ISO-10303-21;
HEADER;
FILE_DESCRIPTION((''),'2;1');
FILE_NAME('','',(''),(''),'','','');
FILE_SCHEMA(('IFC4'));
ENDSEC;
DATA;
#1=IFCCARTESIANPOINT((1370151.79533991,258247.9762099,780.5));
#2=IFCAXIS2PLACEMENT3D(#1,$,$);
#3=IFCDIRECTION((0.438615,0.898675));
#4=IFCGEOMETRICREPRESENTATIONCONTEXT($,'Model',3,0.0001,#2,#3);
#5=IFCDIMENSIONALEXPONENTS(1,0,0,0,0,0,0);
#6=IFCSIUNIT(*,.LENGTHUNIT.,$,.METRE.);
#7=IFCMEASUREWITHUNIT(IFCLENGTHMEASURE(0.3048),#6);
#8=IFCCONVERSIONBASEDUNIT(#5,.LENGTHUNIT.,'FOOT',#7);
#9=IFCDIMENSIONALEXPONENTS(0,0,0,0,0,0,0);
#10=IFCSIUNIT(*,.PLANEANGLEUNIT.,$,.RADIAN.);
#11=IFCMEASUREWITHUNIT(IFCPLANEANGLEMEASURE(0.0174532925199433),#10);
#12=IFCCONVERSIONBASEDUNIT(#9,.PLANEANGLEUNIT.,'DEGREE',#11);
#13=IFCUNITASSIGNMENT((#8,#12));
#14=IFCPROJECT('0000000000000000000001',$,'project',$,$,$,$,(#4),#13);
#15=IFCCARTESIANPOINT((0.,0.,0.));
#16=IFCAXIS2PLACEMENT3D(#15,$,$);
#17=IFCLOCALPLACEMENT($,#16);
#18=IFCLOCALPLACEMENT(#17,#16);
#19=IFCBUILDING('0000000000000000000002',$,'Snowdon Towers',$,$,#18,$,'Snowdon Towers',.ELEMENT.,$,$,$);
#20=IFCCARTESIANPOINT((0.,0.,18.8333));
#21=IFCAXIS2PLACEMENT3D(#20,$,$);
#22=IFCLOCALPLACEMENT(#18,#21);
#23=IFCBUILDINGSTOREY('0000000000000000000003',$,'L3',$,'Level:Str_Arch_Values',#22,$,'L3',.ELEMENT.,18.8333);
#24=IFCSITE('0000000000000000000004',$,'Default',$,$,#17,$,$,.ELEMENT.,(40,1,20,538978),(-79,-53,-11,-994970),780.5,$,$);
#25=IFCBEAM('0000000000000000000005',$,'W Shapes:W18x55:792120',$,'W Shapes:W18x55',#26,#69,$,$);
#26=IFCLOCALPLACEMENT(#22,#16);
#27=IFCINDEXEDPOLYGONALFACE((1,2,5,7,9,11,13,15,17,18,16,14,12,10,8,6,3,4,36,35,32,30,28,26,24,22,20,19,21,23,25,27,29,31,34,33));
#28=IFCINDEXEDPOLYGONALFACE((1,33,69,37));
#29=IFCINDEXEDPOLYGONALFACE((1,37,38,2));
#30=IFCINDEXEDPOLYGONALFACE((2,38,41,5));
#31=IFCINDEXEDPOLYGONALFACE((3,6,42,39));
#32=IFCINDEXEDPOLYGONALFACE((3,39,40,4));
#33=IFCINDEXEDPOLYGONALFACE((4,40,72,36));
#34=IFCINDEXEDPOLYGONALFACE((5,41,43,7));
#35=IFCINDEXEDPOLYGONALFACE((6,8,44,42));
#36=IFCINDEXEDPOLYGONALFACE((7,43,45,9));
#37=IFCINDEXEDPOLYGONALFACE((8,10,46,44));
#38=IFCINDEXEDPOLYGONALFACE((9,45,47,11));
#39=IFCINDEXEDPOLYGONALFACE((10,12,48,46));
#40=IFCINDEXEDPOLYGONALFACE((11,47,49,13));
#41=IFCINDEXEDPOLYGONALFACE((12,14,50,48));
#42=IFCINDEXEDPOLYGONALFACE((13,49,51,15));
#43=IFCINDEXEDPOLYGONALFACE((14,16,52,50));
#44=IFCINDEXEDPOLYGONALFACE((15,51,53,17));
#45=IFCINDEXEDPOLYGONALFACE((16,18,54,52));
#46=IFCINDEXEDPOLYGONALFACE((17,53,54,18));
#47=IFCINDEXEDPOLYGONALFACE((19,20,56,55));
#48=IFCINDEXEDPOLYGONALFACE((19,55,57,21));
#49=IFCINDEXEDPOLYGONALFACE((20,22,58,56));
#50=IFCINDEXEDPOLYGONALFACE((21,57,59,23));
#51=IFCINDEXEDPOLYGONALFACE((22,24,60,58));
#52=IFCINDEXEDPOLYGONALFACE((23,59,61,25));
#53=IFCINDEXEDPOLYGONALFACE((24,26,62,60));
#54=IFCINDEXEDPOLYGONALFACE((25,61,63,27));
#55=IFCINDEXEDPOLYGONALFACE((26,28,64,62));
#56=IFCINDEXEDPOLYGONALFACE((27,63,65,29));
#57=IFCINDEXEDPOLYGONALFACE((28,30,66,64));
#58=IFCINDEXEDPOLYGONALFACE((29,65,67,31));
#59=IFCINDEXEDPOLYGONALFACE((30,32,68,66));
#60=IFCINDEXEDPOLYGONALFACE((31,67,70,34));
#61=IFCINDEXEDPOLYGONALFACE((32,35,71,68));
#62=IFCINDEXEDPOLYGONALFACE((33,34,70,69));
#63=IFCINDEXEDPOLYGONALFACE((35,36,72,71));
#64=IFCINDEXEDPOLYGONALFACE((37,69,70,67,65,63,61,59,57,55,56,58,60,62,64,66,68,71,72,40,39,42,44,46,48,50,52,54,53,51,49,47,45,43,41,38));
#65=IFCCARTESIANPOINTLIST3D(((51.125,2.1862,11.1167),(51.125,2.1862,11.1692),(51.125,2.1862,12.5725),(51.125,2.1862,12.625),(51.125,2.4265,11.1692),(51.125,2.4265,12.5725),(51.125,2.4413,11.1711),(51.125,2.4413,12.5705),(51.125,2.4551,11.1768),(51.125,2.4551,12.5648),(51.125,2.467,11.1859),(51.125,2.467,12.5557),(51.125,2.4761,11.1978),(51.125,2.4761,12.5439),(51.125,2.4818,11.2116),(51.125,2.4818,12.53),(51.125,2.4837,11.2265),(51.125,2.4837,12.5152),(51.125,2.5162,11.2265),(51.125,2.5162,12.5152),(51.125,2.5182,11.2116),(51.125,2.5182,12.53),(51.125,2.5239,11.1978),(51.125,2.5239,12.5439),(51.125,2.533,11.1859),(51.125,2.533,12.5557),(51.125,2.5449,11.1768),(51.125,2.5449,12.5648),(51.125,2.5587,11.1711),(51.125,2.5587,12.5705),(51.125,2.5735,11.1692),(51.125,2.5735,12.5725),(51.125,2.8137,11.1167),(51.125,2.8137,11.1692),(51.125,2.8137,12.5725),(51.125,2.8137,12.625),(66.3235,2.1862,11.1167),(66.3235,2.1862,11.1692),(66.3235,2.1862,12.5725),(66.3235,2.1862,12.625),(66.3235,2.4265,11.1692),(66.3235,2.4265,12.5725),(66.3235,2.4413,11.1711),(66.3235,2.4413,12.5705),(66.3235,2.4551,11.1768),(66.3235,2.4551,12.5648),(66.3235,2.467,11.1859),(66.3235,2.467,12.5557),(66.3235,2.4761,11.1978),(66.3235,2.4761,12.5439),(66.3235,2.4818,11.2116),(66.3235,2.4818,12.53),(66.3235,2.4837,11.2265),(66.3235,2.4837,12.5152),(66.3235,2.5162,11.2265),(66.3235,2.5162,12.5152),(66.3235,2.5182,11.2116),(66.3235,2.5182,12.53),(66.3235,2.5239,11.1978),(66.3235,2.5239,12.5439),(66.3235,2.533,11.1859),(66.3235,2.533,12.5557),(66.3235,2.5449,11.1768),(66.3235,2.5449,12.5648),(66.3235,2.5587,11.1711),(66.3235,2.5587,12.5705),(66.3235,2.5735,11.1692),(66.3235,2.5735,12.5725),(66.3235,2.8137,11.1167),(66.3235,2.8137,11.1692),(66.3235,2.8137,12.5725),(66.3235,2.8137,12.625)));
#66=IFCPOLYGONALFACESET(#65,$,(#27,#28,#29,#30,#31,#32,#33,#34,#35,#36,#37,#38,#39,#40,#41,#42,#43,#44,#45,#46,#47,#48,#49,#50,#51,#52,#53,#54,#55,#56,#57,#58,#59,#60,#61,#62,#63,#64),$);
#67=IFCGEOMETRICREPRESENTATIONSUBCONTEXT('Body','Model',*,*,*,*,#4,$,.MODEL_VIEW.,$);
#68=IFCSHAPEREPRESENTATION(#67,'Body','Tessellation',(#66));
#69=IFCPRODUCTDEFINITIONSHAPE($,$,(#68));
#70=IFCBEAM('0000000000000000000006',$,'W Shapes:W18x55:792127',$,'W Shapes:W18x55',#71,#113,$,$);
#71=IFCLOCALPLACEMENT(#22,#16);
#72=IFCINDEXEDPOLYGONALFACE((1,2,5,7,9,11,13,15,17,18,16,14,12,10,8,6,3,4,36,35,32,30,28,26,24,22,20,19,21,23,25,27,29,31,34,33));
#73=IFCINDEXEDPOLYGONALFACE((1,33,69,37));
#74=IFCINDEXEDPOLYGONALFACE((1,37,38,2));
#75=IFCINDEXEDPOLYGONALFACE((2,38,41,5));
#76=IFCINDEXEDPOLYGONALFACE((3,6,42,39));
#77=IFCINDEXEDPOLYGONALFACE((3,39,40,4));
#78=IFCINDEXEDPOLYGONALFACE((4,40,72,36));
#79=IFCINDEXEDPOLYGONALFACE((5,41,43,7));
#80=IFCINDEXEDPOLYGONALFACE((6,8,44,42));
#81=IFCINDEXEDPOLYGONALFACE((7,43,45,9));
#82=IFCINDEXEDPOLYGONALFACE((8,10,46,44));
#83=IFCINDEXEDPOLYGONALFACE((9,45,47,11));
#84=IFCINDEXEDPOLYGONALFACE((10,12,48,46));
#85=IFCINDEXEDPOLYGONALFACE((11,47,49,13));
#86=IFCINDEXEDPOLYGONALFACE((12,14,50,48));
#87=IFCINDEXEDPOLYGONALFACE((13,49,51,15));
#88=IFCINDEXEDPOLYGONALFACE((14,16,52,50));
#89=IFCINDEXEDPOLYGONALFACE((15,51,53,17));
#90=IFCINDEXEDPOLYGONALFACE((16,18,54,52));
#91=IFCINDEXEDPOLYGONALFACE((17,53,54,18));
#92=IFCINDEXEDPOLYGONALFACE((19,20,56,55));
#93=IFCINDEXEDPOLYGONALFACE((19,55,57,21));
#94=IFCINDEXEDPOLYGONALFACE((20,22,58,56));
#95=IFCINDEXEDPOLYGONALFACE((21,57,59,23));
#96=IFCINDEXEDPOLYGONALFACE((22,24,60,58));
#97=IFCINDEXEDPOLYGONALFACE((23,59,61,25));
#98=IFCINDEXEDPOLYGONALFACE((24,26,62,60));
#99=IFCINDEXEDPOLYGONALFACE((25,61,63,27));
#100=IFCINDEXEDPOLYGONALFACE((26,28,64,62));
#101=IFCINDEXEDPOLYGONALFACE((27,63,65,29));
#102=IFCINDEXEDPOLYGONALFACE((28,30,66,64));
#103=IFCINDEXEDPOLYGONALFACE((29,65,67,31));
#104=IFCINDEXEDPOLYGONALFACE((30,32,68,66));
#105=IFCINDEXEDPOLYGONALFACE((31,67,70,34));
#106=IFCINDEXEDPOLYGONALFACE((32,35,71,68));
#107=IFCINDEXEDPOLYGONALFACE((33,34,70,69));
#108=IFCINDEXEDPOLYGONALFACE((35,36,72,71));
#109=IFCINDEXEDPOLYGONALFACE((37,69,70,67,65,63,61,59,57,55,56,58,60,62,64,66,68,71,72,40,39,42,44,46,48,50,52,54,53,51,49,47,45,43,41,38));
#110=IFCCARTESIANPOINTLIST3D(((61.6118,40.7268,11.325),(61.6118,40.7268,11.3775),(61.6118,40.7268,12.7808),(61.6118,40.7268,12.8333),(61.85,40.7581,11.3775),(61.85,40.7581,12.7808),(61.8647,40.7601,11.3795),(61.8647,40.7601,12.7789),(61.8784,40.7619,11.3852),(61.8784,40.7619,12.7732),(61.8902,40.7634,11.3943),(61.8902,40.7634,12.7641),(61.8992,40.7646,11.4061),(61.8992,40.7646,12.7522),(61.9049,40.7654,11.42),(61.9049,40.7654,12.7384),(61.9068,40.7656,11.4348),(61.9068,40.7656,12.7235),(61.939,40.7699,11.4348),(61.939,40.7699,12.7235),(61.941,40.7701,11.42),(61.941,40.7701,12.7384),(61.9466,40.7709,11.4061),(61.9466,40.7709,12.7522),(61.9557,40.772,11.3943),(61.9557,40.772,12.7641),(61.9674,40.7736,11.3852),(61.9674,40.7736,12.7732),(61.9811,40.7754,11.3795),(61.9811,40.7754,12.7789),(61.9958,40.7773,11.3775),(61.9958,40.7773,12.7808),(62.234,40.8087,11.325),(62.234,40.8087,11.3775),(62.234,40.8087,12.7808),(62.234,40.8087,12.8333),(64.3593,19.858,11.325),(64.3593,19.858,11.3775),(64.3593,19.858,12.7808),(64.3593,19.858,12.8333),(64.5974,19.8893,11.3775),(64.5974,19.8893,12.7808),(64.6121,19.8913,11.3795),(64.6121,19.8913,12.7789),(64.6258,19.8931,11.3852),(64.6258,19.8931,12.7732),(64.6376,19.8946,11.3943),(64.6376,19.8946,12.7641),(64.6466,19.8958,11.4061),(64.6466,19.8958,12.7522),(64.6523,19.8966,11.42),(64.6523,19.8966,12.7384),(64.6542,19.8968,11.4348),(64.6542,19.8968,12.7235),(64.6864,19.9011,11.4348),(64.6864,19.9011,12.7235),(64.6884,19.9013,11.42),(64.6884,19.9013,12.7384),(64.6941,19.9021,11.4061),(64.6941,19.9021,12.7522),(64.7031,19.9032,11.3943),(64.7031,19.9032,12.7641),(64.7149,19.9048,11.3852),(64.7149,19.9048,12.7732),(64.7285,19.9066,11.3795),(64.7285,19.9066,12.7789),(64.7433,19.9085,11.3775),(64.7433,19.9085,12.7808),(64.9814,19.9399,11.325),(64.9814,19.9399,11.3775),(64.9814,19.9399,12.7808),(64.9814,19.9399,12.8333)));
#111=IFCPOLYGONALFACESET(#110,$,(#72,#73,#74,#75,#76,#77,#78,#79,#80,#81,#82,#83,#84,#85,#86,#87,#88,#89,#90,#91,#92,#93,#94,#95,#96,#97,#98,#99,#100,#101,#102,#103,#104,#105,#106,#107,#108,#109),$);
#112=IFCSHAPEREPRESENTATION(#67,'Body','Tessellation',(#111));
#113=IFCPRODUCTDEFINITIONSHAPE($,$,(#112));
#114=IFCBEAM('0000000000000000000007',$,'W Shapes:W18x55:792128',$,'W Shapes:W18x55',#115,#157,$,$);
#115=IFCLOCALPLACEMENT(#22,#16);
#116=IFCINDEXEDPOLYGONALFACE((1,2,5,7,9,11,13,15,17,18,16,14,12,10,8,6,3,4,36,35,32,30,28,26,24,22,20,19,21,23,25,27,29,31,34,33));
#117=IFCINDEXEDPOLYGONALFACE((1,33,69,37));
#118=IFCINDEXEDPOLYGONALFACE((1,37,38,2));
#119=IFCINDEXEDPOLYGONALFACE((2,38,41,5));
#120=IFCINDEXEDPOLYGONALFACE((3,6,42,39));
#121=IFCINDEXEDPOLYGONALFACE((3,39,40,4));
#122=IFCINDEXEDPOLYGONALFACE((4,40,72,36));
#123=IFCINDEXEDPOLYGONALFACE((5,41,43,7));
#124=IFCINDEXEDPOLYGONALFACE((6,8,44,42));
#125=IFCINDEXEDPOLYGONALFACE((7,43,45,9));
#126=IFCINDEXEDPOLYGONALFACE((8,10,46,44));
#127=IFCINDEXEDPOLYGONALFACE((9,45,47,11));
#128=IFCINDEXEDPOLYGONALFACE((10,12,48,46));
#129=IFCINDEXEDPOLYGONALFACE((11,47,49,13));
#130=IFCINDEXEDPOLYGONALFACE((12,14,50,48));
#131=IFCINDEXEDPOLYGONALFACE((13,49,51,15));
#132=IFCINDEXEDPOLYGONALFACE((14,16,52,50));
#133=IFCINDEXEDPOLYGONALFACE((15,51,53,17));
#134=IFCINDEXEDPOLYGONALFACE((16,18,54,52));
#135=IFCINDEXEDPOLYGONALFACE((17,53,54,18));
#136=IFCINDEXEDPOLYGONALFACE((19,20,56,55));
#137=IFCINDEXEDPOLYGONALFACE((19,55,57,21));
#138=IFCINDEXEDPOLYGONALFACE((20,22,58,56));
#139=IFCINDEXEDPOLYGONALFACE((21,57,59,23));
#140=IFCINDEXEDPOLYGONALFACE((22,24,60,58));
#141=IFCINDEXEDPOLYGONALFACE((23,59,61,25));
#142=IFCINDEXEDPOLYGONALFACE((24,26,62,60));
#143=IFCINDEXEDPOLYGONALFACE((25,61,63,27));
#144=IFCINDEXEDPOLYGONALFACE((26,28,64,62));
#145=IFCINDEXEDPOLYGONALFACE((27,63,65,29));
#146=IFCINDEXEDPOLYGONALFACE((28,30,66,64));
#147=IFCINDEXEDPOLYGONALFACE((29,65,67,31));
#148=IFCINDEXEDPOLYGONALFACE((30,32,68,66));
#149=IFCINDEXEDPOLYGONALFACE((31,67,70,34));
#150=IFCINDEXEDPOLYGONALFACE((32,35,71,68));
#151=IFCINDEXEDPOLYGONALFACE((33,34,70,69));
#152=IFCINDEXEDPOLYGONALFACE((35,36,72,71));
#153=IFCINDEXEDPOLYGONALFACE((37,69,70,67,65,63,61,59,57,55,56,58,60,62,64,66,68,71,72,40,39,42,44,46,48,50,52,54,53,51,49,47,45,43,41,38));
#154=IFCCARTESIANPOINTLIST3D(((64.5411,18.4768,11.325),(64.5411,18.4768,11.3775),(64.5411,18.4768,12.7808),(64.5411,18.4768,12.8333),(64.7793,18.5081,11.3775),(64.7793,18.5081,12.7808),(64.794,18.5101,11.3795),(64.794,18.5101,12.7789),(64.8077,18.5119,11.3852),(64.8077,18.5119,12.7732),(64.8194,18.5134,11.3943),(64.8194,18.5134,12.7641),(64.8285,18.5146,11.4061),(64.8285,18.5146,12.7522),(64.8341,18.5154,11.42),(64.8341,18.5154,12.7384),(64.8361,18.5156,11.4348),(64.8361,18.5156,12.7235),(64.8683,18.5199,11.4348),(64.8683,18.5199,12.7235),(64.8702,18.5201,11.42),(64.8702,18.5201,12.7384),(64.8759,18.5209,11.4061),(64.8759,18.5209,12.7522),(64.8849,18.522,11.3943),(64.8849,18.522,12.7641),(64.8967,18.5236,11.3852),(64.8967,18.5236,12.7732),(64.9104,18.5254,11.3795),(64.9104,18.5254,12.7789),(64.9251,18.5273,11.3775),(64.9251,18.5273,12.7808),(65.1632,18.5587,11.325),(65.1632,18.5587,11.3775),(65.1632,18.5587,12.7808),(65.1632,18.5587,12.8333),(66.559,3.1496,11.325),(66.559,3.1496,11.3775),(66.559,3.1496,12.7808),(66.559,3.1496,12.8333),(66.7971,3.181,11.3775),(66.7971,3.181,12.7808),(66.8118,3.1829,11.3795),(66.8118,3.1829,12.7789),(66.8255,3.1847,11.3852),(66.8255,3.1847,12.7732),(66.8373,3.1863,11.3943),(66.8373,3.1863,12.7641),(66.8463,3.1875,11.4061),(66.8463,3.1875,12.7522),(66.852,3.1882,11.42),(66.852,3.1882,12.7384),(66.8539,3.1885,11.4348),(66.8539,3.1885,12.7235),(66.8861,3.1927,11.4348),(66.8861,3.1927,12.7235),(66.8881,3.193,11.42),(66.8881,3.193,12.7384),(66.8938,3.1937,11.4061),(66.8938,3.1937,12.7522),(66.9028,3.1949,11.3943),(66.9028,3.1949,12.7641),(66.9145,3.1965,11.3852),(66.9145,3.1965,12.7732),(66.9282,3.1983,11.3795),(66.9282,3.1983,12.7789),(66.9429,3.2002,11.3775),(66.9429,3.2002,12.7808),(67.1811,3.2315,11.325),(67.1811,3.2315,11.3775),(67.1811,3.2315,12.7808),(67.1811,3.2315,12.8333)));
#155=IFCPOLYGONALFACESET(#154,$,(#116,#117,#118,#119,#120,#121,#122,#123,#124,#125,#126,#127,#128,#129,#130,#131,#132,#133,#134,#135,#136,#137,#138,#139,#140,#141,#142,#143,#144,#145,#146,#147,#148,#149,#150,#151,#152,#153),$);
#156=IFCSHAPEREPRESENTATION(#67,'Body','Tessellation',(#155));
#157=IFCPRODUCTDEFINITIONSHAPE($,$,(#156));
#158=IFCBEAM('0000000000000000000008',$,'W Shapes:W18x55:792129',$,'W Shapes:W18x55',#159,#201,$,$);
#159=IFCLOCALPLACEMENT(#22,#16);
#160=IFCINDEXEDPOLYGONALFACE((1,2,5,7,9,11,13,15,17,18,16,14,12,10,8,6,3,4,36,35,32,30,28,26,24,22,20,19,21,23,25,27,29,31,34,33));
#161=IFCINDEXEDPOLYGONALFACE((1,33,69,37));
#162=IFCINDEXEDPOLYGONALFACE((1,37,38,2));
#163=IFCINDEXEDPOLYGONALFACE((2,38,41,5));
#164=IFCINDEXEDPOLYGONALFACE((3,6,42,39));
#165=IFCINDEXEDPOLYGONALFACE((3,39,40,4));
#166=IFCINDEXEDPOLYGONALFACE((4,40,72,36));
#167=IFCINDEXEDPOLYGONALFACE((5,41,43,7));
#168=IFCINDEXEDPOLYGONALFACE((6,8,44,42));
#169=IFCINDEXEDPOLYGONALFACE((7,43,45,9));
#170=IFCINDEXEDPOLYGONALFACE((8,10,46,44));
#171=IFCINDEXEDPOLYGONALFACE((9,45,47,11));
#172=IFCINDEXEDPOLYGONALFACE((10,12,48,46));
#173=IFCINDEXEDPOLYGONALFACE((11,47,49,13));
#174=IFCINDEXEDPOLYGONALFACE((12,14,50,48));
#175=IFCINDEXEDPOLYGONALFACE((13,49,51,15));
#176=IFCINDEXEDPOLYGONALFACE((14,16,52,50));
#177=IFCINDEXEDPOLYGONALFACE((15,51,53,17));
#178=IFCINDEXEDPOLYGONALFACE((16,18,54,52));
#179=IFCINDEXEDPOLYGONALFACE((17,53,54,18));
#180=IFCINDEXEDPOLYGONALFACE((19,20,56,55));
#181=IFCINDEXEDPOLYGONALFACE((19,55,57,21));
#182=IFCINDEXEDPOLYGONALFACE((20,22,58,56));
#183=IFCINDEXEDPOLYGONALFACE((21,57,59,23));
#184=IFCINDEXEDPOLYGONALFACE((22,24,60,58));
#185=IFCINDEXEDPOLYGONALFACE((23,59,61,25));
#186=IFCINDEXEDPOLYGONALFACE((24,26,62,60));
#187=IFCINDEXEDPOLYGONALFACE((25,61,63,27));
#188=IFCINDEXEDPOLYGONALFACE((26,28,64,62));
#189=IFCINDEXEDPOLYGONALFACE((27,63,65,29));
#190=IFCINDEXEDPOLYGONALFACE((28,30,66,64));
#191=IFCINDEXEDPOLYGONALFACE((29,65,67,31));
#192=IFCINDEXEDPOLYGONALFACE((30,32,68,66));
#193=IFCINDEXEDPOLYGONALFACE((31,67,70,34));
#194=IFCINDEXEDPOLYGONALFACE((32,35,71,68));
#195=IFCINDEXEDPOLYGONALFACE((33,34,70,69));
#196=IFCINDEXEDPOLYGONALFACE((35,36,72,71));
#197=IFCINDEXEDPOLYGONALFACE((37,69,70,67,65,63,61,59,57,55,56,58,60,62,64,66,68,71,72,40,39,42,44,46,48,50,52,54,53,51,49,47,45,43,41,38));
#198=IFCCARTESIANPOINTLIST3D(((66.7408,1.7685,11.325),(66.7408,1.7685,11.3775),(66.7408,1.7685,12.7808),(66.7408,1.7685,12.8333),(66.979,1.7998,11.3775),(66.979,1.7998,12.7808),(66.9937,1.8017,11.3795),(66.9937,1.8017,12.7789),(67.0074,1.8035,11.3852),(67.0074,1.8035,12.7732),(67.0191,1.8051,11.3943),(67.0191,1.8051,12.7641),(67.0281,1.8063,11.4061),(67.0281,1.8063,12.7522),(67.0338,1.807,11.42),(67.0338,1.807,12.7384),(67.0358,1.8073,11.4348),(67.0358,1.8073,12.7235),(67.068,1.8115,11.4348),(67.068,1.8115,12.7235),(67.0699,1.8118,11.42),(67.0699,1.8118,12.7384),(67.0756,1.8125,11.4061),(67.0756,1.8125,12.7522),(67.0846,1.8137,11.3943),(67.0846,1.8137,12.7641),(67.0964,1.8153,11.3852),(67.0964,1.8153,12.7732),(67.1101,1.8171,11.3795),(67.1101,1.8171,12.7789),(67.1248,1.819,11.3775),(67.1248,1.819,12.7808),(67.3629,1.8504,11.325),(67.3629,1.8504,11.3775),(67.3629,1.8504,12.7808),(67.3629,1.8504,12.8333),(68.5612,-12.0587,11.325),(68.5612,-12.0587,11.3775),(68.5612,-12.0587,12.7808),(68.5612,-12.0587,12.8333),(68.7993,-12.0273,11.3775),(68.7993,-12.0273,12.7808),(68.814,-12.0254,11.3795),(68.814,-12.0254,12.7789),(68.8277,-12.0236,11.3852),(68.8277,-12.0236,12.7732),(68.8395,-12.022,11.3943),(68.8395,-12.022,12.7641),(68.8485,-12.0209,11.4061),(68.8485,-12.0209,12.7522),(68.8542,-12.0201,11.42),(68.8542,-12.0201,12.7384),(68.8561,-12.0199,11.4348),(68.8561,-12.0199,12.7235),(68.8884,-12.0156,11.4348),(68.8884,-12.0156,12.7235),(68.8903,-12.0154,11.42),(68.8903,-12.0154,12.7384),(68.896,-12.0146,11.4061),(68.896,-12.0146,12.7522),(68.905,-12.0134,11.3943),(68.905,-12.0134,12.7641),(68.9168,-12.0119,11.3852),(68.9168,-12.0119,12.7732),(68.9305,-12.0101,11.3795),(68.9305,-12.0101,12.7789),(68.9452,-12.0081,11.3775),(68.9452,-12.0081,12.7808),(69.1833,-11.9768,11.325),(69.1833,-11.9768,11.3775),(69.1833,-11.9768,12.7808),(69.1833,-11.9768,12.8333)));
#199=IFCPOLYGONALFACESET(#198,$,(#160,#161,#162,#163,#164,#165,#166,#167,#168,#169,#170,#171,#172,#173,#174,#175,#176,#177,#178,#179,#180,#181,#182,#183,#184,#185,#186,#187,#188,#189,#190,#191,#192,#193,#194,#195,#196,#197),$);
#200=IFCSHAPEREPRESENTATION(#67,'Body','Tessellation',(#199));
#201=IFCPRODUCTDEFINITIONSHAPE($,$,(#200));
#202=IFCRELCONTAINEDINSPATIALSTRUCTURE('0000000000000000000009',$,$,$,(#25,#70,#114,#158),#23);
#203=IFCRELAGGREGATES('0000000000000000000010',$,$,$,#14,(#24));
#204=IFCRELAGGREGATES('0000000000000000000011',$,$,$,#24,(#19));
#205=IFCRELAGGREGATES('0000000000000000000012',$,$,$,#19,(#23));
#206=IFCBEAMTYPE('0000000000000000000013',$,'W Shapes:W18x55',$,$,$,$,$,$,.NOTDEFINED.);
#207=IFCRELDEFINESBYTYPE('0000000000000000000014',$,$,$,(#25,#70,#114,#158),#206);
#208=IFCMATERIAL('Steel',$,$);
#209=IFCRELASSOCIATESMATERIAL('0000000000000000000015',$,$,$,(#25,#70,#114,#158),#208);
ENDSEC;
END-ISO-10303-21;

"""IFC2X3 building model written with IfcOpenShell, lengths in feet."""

from ifc_helpers import new_model, entity, si_unit, converted_unit, direction, frame, frame_2d, origin, place, context, subcontext, project, spatial, i_section, extrude, material, type_object, element, save


model = new_model("IFC2X3")

# Units and contexts
model_context = context("Model", 3, precision=0.0001, world=frame((1370151.79533991, 258247.9762099, 780.5)), true_north=direction((0.438615, 0.898675)))
body_context = subcontext(model_context, "Body", "Model", "MODEL_VIEW")
ifc_project = project(units=[converted_unit("LENGTHUNIT", "FOOT", entity("IfcLengthMeasure", 0.3048), si_unit("LENGTHUNIT", "METRE"), dimensions=[1, 0, 0, 0, 0, 0, 0]), converted_unit("PLANEANGLEUNIT", "DEGREE", entity("IfcPlaneAngleMeasure", 0.0174532925199433), si_unit("PLANEANGLEUNIT", "RADIAN"), dimensions=[0, 0, 0, 0, 0, 0, 0])], contexts=[model_context])

# Site, building, storey
site_placement = place(None, origin())
site = spatial("IfcSite", under=ifc_project, at=site_placement, Name="Default", CompositionType="ELEMENT", RefLatitude=(40, 1, 20, 538978), RefLongitude=(-79, -53, -11, -994970), RefElevation=780.5)
building_placement = place(site_placement, origin())
building = spatial("IfcBuilding", under=site, at=building_placement, Name="Snowdon Towers", LongName="Snowdon Towers", CompositionType="ELEMENT")
storey_placement = place(building_placement, frame((0.0, 0.0, 18.8333)))
storey = spatial("IfcBuildingStorey", under=building, at=storey_placement, Name="L3", ObjectType="Level:Str_Arch_Values", LongName="L3", CompositionType="ELEMENT", Elevation=18.8333)

# Beams
ifc_material = material(Name="Steel")
beam_type_1 = type_object("IfcBeamType", Name="W Shapes:W18x55", PredefinedType="NOTDEFINED")
beam_1_placement = place(storey_placement, frame((51.125, 2.5, 12.8333)))
element("IfcBeam", 1, at=beam_1_placement, inside=storey, type_object=beam_type_1, material=ifc_material, Name="W Shapes:W18x55:792120", ObjectType="W Shapes:W18x55", context=body_context, shape_type="SweptSolid", body=[
    extrude(i_section(OverallWidth=0.6275, OverallDepth=1.5083, WebThickness=0.0325, FlangeThickness=0.0525, FilletRadius=0.0573, at=frame_2d((0.0, 0.0), x_axis=(0.0, 1.0))), frame((0.0, 0.0, -0.9625), z_axis=(1.0, 0.0, 0.0), x_axis=(0.0, 0.0, -1.0)), (0.0, 0.0, 1.0), 15.1985),
])
beam_2_placement = place(storey_placement, frame((61.8201, 41.5489, 12.8333), z_axis=(0.0, 0.0, 1.0), x_axis=(0.130526, -0.991445, 0.0)))
element("IfcBeam", 2, at=beam_2_placement, inside=storey, type_object=beam_type_1, material=ifc_material, Name="W Shapes:W18x55:792127", ObjectType="W Shapes:W18x55", context=body_context, shape_type="SweptSolid", body=[
    extrude(i_section(OverallWidth=0.6275, OverallDepth=1.5083, WebThickness=0.0325, FlangeThickness=0.0525, FilletRadius=0.0573, at=frame_2d((0.0, 0.0), x_axis=(0.0, 1.0))), frame((0.7879, 0.0, -0.7542), z_axis=(1.0, 0.0, 0.0), x_axis=(0.0, 0.0, -1.0)), (0.0, 0.0, 1.0), 21.0489),
])
beam_3_placement = place(storey_placement, frame((64.7713, 19.1322, 12.8333), z_axis=(0.0, 0.0, 1.0), x_axis=(0.130526, -0.991445, 0.0)))
element("IfcBeam", 3, at=beam_3_placement, inside=storey, type_object=beam_type_1, material=ifc_material, Name="W Shapes:W18x55:792128", ObjectType="W Shapes:W18x55", context=body_context, shape_type="SweptSolid", body=[
    extrude(i_section(OverallWidth=0.6275, OverallDepth=1.5083, WebThickness=0.0325, FlangeThickness=0.0525, FilletRadius=0.0573, at=frame_2d((0.0, 0.0), x_axis=(0.0, 1.0))), frame((0.6198, 0.0, -0.7542), z_axis=(1.0, 0.0, 0.0), x_axis=(0.0, 0.0, -1.0)), (0.0, 0.0, 1.0), 15.4594),
])
beam_4_placement = place(storey_placement, frame((66.971, 2.4239, 12.8333), z_axis=(0.0, 0.0, 1.0), x_axis=(0.130526, -0.991445, 0.0)))
element("IfcBeam", 4, at=beam_4_placement, inside=storey, type_object=beam_type_1, material=ifc_material, Name="W Shapes:W18x55:792129", ObjectType="W Shapes:W18x55", context=body_context, shape_type="SweptSolid", body=[
    extrude(i_section(OverallWidth=0.6275, OverallDepth=1.5083, WebThickness=0.0325, FlangeThickness=0.0525, FilletRadius=0.0573, at=frame_2d((0.0, 0.0), x_axis=(0.0, 1.0))), frame((0.6198, 0.0, -0.7542), z_axis=(1.0, 0.0, 0.0), x_axis=(0.0, 0.0, -1.0)), (0.0, 0.0, 1.0), 13.9465),
])

save(model, "model.ifc")
